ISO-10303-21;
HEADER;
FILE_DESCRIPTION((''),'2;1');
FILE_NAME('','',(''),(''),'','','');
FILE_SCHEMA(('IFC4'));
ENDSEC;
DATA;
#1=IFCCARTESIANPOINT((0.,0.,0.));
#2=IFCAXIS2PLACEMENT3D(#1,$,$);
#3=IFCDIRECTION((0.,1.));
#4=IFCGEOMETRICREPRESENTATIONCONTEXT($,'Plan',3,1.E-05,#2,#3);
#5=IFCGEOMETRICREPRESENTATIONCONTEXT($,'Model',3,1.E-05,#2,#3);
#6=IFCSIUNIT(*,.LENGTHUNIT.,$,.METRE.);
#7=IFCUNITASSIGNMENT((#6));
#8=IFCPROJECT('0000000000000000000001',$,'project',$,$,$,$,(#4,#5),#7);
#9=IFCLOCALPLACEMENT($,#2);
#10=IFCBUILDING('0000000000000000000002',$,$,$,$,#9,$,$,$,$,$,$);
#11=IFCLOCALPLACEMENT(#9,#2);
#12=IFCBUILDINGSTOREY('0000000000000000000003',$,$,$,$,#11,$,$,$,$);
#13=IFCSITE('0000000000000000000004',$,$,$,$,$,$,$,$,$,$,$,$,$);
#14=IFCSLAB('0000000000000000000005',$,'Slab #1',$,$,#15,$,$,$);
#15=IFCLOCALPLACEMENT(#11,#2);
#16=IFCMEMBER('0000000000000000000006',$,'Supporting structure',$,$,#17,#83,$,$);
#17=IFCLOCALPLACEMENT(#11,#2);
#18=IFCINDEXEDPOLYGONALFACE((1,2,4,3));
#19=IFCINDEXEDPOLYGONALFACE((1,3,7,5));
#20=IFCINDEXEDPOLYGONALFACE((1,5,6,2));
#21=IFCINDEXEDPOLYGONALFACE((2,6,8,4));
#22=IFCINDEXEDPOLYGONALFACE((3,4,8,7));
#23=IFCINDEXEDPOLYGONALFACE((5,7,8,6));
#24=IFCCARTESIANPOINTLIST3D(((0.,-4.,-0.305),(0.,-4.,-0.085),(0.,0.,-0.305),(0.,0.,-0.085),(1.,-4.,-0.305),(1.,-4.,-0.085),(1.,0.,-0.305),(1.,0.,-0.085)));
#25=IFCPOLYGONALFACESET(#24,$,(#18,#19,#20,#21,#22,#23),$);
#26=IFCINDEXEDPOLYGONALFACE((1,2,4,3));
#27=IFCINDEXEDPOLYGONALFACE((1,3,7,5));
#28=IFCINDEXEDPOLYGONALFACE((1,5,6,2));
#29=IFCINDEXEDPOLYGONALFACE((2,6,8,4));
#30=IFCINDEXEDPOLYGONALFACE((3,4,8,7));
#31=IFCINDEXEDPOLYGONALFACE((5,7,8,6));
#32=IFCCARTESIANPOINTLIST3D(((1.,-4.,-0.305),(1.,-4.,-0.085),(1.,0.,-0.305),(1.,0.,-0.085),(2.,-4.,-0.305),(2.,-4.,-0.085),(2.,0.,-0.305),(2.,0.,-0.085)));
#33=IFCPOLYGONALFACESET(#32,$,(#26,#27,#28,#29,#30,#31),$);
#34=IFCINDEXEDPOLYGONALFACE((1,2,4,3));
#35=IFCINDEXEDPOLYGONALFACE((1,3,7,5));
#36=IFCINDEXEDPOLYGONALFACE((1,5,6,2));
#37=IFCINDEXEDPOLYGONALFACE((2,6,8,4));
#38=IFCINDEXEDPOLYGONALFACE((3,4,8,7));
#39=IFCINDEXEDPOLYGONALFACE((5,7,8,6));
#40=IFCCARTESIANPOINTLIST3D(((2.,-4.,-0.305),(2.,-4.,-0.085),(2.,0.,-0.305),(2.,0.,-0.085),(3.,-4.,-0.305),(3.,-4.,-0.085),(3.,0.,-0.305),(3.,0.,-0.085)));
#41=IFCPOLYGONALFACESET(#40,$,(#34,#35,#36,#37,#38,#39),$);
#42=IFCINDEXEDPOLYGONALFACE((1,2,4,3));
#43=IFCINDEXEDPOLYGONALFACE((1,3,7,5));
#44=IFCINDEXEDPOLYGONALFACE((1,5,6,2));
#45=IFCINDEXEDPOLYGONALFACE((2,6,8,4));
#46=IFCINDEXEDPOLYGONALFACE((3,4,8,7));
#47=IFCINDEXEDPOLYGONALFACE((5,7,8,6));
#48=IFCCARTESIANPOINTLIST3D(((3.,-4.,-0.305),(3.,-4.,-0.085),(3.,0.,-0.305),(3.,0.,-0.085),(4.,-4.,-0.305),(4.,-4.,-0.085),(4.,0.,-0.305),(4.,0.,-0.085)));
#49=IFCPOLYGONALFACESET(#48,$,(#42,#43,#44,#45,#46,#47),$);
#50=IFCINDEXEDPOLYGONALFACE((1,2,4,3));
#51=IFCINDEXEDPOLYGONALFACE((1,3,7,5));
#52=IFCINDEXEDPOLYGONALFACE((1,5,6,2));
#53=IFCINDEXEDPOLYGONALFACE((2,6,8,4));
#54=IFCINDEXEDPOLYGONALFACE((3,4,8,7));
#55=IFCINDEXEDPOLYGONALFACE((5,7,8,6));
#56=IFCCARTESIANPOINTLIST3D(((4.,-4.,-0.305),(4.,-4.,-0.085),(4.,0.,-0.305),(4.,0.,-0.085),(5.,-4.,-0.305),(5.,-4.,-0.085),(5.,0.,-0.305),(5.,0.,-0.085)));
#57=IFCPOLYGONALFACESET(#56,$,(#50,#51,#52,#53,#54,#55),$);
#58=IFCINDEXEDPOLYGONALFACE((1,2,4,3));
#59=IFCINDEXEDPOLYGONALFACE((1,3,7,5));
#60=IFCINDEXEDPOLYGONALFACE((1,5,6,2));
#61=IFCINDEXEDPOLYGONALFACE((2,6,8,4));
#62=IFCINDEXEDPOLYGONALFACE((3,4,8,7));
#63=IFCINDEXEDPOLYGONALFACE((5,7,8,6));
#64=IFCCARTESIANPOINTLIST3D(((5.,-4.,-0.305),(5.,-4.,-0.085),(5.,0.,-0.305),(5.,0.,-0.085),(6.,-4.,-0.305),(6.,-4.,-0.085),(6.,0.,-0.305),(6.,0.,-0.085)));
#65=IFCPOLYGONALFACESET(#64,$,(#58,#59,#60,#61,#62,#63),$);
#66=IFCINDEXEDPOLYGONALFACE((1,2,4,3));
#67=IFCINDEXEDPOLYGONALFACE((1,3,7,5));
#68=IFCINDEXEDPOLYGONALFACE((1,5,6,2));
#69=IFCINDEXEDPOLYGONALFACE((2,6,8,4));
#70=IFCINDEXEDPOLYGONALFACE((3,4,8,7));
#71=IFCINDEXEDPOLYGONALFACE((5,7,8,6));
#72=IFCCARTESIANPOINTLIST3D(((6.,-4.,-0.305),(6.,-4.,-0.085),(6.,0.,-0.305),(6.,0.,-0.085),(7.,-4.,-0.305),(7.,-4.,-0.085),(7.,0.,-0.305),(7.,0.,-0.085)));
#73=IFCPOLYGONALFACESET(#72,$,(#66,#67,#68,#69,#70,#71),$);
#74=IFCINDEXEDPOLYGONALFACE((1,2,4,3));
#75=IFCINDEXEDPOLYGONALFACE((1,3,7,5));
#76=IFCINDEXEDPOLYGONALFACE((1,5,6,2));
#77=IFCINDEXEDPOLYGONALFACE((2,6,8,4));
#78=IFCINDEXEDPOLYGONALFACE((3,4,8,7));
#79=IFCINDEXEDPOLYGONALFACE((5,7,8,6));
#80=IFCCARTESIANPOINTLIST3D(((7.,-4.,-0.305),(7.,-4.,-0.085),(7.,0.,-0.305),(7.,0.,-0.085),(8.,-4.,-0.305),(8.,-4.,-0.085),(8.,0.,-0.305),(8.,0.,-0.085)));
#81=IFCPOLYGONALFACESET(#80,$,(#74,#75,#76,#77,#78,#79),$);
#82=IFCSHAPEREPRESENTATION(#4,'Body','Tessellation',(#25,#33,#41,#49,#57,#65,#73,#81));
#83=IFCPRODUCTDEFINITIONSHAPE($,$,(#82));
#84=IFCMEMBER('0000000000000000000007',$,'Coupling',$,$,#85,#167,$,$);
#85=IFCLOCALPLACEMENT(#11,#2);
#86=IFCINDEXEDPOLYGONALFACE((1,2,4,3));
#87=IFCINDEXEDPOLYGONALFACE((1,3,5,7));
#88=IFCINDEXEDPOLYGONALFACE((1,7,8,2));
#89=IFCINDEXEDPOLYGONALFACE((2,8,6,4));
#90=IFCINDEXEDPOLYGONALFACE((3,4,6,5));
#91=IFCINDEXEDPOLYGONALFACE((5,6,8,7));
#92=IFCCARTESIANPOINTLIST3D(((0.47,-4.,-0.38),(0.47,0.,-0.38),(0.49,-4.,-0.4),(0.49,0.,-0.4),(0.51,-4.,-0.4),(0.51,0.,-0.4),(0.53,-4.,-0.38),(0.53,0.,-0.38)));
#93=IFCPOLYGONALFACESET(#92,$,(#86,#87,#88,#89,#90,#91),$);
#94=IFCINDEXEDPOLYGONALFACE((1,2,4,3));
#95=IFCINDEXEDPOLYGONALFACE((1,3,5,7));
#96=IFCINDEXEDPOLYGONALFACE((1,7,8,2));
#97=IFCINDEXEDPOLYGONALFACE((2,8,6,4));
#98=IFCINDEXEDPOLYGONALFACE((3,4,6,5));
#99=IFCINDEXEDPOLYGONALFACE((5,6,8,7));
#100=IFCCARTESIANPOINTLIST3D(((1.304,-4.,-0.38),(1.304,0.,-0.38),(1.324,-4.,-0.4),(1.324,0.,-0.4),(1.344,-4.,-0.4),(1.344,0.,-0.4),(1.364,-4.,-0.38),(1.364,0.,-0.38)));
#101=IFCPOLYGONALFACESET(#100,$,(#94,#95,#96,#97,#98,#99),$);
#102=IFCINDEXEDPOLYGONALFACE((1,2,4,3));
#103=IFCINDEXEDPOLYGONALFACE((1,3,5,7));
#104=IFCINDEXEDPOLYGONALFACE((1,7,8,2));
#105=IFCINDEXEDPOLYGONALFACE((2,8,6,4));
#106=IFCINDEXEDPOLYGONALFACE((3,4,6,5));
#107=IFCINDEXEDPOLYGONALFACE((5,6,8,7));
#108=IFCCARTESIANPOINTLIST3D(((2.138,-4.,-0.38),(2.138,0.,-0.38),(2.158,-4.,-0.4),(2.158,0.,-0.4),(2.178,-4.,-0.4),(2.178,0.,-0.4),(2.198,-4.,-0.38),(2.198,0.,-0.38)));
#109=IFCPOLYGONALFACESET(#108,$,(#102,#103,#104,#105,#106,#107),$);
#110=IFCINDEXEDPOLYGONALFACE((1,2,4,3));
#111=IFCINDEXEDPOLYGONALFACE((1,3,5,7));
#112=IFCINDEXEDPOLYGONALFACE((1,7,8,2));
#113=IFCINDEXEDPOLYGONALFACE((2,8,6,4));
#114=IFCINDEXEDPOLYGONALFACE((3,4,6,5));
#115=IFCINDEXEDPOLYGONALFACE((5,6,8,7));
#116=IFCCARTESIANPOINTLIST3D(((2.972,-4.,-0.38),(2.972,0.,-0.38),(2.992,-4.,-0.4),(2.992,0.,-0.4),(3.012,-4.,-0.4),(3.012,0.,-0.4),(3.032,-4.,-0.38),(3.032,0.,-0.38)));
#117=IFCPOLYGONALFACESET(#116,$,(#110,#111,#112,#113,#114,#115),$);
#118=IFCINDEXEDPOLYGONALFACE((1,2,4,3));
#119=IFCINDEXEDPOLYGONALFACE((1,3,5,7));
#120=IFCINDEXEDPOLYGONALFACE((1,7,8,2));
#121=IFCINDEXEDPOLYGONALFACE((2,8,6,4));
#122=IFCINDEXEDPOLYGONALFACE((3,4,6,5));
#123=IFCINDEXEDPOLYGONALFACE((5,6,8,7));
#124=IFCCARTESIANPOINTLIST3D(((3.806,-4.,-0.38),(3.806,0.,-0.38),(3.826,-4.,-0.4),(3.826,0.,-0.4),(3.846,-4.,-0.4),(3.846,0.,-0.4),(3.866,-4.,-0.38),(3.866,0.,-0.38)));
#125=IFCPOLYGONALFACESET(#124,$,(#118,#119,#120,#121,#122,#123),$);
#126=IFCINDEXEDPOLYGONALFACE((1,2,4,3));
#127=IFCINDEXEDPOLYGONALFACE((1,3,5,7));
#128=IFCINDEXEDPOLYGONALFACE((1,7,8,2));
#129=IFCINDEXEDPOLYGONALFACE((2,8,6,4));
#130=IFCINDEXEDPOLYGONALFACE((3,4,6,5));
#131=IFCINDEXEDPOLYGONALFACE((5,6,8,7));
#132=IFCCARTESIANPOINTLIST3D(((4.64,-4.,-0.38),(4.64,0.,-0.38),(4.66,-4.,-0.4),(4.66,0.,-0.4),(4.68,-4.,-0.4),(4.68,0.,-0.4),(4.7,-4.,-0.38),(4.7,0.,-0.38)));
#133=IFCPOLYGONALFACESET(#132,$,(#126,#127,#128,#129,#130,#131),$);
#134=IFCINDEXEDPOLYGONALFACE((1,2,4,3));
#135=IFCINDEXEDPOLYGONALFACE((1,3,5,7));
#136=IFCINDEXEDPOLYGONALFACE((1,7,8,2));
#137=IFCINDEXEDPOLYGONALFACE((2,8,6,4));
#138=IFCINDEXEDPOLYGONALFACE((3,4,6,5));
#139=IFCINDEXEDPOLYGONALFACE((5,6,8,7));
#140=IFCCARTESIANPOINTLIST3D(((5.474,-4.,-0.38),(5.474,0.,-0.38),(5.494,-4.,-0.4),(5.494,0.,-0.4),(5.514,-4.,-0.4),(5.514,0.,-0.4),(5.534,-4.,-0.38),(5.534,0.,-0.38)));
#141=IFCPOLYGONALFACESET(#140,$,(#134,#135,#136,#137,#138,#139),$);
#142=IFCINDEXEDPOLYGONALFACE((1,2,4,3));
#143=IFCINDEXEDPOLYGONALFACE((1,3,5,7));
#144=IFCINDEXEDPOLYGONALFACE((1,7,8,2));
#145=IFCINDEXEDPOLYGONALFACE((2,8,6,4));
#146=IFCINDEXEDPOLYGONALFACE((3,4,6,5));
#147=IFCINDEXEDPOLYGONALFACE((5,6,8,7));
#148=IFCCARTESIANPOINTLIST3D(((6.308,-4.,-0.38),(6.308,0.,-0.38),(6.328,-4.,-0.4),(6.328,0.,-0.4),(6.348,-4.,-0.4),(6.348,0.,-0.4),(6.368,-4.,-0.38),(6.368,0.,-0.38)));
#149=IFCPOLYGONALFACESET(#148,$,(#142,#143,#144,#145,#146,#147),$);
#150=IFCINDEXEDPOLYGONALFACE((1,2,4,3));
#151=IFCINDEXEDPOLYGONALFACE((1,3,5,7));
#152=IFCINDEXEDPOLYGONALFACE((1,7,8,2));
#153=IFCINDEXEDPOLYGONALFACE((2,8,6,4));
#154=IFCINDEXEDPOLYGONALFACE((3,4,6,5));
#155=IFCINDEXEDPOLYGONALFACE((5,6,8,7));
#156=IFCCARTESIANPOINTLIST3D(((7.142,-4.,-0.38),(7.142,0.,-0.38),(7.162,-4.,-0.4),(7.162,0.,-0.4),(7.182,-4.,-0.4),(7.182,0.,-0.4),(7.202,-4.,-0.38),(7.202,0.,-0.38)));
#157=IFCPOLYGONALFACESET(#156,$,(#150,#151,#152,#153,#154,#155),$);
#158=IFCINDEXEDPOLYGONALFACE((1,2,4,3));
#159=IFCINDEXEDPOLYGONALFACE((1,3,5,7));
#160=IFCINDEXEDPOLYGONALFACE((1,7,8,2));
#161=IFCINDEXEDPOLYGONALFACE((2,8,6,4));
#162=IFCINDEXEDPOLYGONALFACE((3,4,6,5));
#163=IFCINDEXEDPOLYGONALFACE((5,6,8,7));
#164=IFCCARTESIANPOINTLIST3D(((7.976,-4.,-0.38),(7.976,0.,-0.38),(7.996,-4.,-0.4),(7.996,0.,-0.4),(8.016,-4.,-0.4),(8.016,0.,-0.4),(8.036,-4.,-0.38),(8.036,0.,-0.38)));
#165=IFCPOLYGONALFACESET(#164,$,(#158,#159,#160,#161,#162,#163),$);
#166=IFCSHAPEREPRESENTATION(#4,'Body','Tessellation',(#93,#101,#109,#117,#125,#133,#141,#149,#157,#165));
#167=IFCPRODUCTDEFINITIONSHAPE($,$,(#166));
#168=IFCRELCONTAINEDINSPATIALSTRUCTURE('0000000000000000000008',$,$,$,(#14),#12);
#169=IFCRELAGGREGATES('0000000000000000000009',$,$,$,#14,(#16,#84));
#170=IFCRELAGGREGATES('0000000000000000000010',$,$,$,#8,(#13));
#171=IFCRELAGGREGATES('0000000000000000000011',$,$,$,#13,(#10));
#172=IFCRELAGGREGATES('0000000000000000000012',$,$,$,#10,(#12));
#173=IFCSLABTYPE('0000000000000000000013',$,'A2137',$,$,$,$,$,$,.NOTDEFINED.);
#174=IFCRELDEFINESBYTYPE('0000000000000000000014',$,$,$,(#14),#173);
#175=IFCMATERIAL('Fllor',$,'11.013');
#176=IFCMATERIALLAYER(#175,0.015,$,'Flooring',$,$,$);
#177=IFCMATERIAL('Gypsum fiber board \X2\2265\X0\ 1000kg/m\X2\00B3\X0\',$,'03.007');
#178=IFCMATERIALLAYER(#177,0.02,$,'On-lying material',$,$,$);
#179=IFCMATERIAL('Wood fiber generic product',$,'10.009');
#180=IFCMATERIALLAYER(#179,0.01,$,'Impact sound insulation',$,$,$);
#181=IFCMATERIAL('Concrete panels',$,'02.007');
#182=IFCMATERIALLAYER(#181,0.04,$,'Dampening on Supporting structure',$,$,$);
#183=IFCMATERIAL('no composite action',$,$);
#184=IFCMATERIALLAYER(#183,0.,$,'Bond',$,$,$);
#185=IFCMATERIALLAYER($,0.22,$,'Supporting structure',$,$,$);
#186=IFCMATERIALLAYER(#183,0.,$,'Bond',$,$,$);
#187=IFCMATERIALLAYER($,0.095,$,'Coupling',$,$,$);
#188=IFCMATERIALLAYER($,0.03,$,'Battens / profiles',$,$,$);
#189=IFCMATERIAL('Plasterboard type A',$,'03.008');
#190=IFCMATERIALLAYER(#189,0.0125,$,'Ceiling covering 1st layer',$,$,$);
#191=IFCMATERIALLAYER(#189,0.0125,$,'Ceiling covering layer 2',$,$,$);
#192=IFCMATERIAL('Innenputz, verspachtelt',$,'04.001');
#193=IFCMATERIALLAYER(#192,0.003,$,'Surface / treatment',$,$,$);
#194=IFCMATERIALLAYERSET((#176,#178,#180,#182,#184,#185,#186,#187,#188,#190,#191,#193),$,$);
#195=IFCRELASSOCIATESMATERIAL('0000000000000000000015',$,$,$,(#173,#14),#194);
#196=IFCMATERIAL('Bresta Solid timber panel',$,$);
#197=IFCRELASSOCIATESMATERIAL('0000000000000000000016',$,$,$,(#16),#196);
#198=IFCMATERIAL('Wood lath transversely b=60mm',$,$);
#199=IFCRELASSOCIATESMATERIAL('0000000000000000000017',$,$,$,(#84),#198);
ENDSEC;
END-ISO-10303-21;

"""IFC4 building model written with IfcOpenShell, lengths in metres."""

from ifc_helpers import new_model, si_unit, direction, frame, frame_2d, origin, place, context, project, spatial, polyline, rectangle, outline, extrude, material, layer, layer_set, type_object, element, aggregate, save


model = new_model("IFC4")

# Units and contexts
plan_context = context("Plan", 3, precision=1e-05, world=origin(), true_north=direction((0.0, 1.0)))
model_context = context("Model", 3, precision=1e-05, world=origin(), true_north=direction((0.0, 1.0)))
ifc_project = project(units=[si_unit("LENGTHUNIT", "METRE")], contexts=[plan_context, model_context])

# Site, building, storey
site = spatial("IfcSite", under=ifc_project)
building_placement = place(None, origin())
building = spatial("IfcBuilding", under=site, at=building_placement)
storey_placement = place(building_placement, origin())
storey = spatial("IfcBuildingStorey", under=building, at=storey_placement)

# Slab, members
ifc_material_1 = material(Name="Fllor", Category="11.013")
ifc_layer_1 = layer(ifc_material_1, 0.015, Name="Flooring")
ifc_material_2 = material(Name="Gypsum fiber board ≥ 1000kg/m³", Category="03.007")
ifc_layer_2 = layer(ifc_material_2, 0.02, Name="On-lying material")
ifc_material_3 = material(Name="Wood fiber generic product", Category="10.009")
ifc_layer_3 = layer(ifc_material_3, 0.01, Name="Impact sound insulation")
ifc_material_4 = material(Name="Concrete panels", Category="02.007")
ifc_layer_4 = layer(ifc_material_4, 0.04, Name="Dampening on Supporting structure")
ifc_material_5 = material(Name="no composite action")
ifc_layer_5 = layer(ifc_material_5, 0.0, Name="Bond")
ifc_layer_6 = layer(None, 0.22, Name="Supporting structure")
ifc_layer_7 = layer(ifc_material_5, 0.0, Name="Bond")
ifc_layer_8 = layer(None, 0.095, Name="Coupling")
ifc_layer_9 = layer(None, 0.03, Name="Battens / profiles")
ifc_material_6 = material(Name="Plasterboard type A", Category="03.008")
ifc_layer_10 = layer(ifc_material_6, 0.0125, Name="Ceiling covering 1st layer")
ifc_layer_11 = layer(ifc_material_6, 0.0125, Name="Ceiling covering layer 2")
ifc_material_7 = material(Name="Innenputz, verspachtelt", Category="04.001")
ifc_layer_12 = layer(ifc_material_7, 0.003, Name="Surface / treatment")
ifc_layer_set = layer_set([ifc_layer_1, ifc_layer_2, ifc_layer_3, ifc_layer_4, ifc_layer_5, ifc_layer_6, ifc_layer_7, ifc_layer_8, ifc_layer_9, ifc_layer_10, ifc_layer_11, ifc_layer_12])
slab_type = type_object("IfcSlabType", Name="A2137", PredefinedType="NOTDEFINED", material=ifc_layer_set)
slab_placement = place(None, frame((0.0, 0.0, 0.0), z_axis=(0.0, 0.0, -1.0), x_axis=(1.0, 0.0, 0.0)))
slab = element("IfcSlab", 1, at=slab_placement, inside=storey, type_object=slab_type, material=ifc_layer_set, Name="Slab #1")
ifc_material_8 = material(Name="Bresta Solid timber panel")
member_1_placement = place(slab_placement, origin())
member_1 = element("IfcMember", 2, at=member_1_placement, material=ifc_material_8, Name="Supporting structure", context=plan_context, shape_type="SweptSolid", body=[
    extrude(rectangle(XDim=1.0, YDim=0.22, at=frame_2d((0.5, 0.11), x_axis=(1.0, 0.0))), frame((0.0, 4.0, 0.085), z_axis=(0.0, -1.0, 0.0), x_axis=(1.0, 0.0, 0.0)), (0.0, 0.0, 1.0), 4.0),
    extrude(rectangle(XDim=1.0, YDim=0.22, at=frame_2d((0.5, 0.11), x_axis=(1.0, 0.0))), frame((1.0, 4.0, 0.085), z_axis=(0.0, -1.0, 0.0), x_axis=(1.0, 0.0, 0.0)), (0.0, 0.0, 1.0), 4.0),
    extrude(rectangle(XDim=1.0, YDim=0.22, at=frame_2d((0.5, 0.11), x_axis=(1.0, 0.0))), frame((2.0, 4.0, 0.085), z_axis=(0.0, -1.0, 0.0), x_axis=(1.0, 0.0, 0.0)), (0.0, 0.0, 1.0), 4.0),
    extrude(rectangle(XDim=1.0, YDim=0.22, at=frame_2d((0.5, 0.11), x_axis=(1.0, 0.0))), frame((3.0, 4.0, 0.085), z_axis=(0.0, -1.0, 0.0), x_axis=(1.0, 0.0, 0.0)), (0.0, 0.0, 1.0), 4.0),
    extrude(rectangle(XDim=1.0, YDim=0.22, at=frame_2d((0.5, 0.11), x_axis=(1.0, 0.0))), frame((4.0, 4.0, 0.085), z_axis=(0.0, -1.0, 0.0), x_axis=(1.0, 0.0, 0.0)), (0.0, 0.0, 1.0), 4.0),
    extrude(rectangle(XDim=1.0, YDim=0.22, at=frame_2d((0.5, 0.11), x_axis=(1.0, 0.0))), frame((5.0, 4.0, 0.085), z_axis=(0.0, -1.0, 0.0), x_axis=(1.0, 0.0, 0.0)), (0.0, 0.0, 1.0), 4.0),
    extrude(rectangle(XDim=1.0, YDim=0.22, at=frame_2d((0.5, 0.11), x_axis=(1.0, 0.0))), frame((6.0, 4.0, 0.085), z_axis=(0.0, -1.0, 0.0), x_axis=(1.0, 0.0, 0.0)), (0.0, 0.0, 1.0), 4.0),
    extrude(rectangle(XDim=1.0, YDim=0.22, at=frame_2d((0.5, 0.11), x_axis=(1.0, 0.0))), frame((7.0, 4.0, 0.085), z_axis=(0.0, -1.0, 0.0), x_axis=(1.0, 0.0, 0.0)), (0.0, 0.0, 1.0), 4.0),
])
ifc_material_9 = material(Name="Wood lath transversely b=60mm")
member_2_placement = place(slab_placement, origin())
member_2 = element("IfcMember", 3, at=member_2_placement, material=ifc_material_9, Name="Coupling", context=plan_context, shape_type="SweptSolid", body=[
    extrude(outline(polyline([(0.0, 0.0), (0.06, 0.0), (0.04, 0.02), (0.02, 0.02), (0.0, 0.0)])), frame((0.47, 4.0, 0.38), z_axis=(0.0, -1.0, 0.0), x_axis=(1.0, 0.0, 0.0)), (0.0, 0.0, 1.0), 4.0),
    extrude(outline(polyline([(0.0, 0.0), (0.06, 0.0), (0.04, 0.02), (0.02, 0.02), (0.0, 0.0)])), frame((1.304, 4.0, 0.38), z_axis=(0.0, -1.0, 0.0), x_axis=(1.0, 0.0, 0.0)), (0.0, 0.0, 1.0), 4.0),
    extrude(outline(polyline([(0.0, 0.0), (0.06, 0.0), (0.04, 0.02), (0.02, 0.02), (0.0, 0.0)])), frame((2.138, 4.0, 0.38), z_axis=(0.0, -1.0, 0.0), x_axis=(1.0, 0.0, 0.0)), (0.0, 0.0, 1.0), 4.0),
    extrude(outline(polyline([(0.0, 0.0), (0.06, 0.0), (0.04, 0.02), (0.02, 0.02), (0.0, 0.0)])), frame((2.972, 4.0, 0.38), z_axis=(0.0, -1.0, 0.0), x_axis=(1.0, 0.0, 0.0)), (0.0, 0.0, 1.0), 4.0),
    extrude(outline(polyline([(0.0, 0.0), (0.06, 0.0), (0.04, 0.02), (0.02, 0.02), (0.0, 0.0)])), frame((3.806, 4.0, 0.38), z_axis=(0.0, -1.0, 0.0), x_axis=(1.0, 0.0, 0.0)), (0.0, 0.0, 1.0), 4.0),
    extrude(outline(polyline([(0.0, 0.0), (0.06, 0.0), (0.04, 0.02), (0.02, 0.02), (0.0, 0.0)])), frame((4.64, 4.0, 0.38), z_axis=(0.0, -1.0, 0.0), x_axis=(1.0, 0.0, 0.0)), (0.0, 0.0, 1.0), 4.0),
    extrude(outline(polyline([(0.0, 0.0), (0.06, 0.0), (0.04, 0.02), (0.02, 0.02), (0.0, 0.0)])), frame((5.474, 4.0, 0.38), z_axis=(0.0, -1.0, 0.0), x_axis=(1.0, 0.0, 0.0)), (0.0, 0.0, 1.0), 4.0),
    extrude(outline(polyline([(0.0, 0.0), (0.06, 0.0), (0.04, 0.02), (0.02, 0.02), (0.0, 0.0)])), frame((6.308, 4.0, 0.38), z_axis=(0.0, -1.0, 0.0), x_axis=(1.0, 0.0, 0.0)), (0.0, 0.0, 1.0), 4.0),
    extrude(outline(polyline([(0.0, 0.0), (0.06, 0.0), (0.04, 0.02), (0.02, 0.02), (0.0, 0.0)])), frame((7.142, 4.0, 0.38), z_axis=(0.0, -1.0, 0.0), x_axis=(1.0, 0.0, 0.0)), (0.0, 0.0, 1.0), 4.0),
    extrude(outline(polyline([(0.0, 0.0), (0.06, 0.0), (0.04, 0.02), (0.02, 0.02), (0.0, 0.0)])), frame((7.976, 4.0, 0.38), z_axis=(0.0, -1.0, 0.0), x_axis=(1.0, 0.0, 0.0)), (0.0, 0.0, 1.0), 4.0),
])
aggregate(slab, [member_1, member_2])

save(model, "model.ifc")
